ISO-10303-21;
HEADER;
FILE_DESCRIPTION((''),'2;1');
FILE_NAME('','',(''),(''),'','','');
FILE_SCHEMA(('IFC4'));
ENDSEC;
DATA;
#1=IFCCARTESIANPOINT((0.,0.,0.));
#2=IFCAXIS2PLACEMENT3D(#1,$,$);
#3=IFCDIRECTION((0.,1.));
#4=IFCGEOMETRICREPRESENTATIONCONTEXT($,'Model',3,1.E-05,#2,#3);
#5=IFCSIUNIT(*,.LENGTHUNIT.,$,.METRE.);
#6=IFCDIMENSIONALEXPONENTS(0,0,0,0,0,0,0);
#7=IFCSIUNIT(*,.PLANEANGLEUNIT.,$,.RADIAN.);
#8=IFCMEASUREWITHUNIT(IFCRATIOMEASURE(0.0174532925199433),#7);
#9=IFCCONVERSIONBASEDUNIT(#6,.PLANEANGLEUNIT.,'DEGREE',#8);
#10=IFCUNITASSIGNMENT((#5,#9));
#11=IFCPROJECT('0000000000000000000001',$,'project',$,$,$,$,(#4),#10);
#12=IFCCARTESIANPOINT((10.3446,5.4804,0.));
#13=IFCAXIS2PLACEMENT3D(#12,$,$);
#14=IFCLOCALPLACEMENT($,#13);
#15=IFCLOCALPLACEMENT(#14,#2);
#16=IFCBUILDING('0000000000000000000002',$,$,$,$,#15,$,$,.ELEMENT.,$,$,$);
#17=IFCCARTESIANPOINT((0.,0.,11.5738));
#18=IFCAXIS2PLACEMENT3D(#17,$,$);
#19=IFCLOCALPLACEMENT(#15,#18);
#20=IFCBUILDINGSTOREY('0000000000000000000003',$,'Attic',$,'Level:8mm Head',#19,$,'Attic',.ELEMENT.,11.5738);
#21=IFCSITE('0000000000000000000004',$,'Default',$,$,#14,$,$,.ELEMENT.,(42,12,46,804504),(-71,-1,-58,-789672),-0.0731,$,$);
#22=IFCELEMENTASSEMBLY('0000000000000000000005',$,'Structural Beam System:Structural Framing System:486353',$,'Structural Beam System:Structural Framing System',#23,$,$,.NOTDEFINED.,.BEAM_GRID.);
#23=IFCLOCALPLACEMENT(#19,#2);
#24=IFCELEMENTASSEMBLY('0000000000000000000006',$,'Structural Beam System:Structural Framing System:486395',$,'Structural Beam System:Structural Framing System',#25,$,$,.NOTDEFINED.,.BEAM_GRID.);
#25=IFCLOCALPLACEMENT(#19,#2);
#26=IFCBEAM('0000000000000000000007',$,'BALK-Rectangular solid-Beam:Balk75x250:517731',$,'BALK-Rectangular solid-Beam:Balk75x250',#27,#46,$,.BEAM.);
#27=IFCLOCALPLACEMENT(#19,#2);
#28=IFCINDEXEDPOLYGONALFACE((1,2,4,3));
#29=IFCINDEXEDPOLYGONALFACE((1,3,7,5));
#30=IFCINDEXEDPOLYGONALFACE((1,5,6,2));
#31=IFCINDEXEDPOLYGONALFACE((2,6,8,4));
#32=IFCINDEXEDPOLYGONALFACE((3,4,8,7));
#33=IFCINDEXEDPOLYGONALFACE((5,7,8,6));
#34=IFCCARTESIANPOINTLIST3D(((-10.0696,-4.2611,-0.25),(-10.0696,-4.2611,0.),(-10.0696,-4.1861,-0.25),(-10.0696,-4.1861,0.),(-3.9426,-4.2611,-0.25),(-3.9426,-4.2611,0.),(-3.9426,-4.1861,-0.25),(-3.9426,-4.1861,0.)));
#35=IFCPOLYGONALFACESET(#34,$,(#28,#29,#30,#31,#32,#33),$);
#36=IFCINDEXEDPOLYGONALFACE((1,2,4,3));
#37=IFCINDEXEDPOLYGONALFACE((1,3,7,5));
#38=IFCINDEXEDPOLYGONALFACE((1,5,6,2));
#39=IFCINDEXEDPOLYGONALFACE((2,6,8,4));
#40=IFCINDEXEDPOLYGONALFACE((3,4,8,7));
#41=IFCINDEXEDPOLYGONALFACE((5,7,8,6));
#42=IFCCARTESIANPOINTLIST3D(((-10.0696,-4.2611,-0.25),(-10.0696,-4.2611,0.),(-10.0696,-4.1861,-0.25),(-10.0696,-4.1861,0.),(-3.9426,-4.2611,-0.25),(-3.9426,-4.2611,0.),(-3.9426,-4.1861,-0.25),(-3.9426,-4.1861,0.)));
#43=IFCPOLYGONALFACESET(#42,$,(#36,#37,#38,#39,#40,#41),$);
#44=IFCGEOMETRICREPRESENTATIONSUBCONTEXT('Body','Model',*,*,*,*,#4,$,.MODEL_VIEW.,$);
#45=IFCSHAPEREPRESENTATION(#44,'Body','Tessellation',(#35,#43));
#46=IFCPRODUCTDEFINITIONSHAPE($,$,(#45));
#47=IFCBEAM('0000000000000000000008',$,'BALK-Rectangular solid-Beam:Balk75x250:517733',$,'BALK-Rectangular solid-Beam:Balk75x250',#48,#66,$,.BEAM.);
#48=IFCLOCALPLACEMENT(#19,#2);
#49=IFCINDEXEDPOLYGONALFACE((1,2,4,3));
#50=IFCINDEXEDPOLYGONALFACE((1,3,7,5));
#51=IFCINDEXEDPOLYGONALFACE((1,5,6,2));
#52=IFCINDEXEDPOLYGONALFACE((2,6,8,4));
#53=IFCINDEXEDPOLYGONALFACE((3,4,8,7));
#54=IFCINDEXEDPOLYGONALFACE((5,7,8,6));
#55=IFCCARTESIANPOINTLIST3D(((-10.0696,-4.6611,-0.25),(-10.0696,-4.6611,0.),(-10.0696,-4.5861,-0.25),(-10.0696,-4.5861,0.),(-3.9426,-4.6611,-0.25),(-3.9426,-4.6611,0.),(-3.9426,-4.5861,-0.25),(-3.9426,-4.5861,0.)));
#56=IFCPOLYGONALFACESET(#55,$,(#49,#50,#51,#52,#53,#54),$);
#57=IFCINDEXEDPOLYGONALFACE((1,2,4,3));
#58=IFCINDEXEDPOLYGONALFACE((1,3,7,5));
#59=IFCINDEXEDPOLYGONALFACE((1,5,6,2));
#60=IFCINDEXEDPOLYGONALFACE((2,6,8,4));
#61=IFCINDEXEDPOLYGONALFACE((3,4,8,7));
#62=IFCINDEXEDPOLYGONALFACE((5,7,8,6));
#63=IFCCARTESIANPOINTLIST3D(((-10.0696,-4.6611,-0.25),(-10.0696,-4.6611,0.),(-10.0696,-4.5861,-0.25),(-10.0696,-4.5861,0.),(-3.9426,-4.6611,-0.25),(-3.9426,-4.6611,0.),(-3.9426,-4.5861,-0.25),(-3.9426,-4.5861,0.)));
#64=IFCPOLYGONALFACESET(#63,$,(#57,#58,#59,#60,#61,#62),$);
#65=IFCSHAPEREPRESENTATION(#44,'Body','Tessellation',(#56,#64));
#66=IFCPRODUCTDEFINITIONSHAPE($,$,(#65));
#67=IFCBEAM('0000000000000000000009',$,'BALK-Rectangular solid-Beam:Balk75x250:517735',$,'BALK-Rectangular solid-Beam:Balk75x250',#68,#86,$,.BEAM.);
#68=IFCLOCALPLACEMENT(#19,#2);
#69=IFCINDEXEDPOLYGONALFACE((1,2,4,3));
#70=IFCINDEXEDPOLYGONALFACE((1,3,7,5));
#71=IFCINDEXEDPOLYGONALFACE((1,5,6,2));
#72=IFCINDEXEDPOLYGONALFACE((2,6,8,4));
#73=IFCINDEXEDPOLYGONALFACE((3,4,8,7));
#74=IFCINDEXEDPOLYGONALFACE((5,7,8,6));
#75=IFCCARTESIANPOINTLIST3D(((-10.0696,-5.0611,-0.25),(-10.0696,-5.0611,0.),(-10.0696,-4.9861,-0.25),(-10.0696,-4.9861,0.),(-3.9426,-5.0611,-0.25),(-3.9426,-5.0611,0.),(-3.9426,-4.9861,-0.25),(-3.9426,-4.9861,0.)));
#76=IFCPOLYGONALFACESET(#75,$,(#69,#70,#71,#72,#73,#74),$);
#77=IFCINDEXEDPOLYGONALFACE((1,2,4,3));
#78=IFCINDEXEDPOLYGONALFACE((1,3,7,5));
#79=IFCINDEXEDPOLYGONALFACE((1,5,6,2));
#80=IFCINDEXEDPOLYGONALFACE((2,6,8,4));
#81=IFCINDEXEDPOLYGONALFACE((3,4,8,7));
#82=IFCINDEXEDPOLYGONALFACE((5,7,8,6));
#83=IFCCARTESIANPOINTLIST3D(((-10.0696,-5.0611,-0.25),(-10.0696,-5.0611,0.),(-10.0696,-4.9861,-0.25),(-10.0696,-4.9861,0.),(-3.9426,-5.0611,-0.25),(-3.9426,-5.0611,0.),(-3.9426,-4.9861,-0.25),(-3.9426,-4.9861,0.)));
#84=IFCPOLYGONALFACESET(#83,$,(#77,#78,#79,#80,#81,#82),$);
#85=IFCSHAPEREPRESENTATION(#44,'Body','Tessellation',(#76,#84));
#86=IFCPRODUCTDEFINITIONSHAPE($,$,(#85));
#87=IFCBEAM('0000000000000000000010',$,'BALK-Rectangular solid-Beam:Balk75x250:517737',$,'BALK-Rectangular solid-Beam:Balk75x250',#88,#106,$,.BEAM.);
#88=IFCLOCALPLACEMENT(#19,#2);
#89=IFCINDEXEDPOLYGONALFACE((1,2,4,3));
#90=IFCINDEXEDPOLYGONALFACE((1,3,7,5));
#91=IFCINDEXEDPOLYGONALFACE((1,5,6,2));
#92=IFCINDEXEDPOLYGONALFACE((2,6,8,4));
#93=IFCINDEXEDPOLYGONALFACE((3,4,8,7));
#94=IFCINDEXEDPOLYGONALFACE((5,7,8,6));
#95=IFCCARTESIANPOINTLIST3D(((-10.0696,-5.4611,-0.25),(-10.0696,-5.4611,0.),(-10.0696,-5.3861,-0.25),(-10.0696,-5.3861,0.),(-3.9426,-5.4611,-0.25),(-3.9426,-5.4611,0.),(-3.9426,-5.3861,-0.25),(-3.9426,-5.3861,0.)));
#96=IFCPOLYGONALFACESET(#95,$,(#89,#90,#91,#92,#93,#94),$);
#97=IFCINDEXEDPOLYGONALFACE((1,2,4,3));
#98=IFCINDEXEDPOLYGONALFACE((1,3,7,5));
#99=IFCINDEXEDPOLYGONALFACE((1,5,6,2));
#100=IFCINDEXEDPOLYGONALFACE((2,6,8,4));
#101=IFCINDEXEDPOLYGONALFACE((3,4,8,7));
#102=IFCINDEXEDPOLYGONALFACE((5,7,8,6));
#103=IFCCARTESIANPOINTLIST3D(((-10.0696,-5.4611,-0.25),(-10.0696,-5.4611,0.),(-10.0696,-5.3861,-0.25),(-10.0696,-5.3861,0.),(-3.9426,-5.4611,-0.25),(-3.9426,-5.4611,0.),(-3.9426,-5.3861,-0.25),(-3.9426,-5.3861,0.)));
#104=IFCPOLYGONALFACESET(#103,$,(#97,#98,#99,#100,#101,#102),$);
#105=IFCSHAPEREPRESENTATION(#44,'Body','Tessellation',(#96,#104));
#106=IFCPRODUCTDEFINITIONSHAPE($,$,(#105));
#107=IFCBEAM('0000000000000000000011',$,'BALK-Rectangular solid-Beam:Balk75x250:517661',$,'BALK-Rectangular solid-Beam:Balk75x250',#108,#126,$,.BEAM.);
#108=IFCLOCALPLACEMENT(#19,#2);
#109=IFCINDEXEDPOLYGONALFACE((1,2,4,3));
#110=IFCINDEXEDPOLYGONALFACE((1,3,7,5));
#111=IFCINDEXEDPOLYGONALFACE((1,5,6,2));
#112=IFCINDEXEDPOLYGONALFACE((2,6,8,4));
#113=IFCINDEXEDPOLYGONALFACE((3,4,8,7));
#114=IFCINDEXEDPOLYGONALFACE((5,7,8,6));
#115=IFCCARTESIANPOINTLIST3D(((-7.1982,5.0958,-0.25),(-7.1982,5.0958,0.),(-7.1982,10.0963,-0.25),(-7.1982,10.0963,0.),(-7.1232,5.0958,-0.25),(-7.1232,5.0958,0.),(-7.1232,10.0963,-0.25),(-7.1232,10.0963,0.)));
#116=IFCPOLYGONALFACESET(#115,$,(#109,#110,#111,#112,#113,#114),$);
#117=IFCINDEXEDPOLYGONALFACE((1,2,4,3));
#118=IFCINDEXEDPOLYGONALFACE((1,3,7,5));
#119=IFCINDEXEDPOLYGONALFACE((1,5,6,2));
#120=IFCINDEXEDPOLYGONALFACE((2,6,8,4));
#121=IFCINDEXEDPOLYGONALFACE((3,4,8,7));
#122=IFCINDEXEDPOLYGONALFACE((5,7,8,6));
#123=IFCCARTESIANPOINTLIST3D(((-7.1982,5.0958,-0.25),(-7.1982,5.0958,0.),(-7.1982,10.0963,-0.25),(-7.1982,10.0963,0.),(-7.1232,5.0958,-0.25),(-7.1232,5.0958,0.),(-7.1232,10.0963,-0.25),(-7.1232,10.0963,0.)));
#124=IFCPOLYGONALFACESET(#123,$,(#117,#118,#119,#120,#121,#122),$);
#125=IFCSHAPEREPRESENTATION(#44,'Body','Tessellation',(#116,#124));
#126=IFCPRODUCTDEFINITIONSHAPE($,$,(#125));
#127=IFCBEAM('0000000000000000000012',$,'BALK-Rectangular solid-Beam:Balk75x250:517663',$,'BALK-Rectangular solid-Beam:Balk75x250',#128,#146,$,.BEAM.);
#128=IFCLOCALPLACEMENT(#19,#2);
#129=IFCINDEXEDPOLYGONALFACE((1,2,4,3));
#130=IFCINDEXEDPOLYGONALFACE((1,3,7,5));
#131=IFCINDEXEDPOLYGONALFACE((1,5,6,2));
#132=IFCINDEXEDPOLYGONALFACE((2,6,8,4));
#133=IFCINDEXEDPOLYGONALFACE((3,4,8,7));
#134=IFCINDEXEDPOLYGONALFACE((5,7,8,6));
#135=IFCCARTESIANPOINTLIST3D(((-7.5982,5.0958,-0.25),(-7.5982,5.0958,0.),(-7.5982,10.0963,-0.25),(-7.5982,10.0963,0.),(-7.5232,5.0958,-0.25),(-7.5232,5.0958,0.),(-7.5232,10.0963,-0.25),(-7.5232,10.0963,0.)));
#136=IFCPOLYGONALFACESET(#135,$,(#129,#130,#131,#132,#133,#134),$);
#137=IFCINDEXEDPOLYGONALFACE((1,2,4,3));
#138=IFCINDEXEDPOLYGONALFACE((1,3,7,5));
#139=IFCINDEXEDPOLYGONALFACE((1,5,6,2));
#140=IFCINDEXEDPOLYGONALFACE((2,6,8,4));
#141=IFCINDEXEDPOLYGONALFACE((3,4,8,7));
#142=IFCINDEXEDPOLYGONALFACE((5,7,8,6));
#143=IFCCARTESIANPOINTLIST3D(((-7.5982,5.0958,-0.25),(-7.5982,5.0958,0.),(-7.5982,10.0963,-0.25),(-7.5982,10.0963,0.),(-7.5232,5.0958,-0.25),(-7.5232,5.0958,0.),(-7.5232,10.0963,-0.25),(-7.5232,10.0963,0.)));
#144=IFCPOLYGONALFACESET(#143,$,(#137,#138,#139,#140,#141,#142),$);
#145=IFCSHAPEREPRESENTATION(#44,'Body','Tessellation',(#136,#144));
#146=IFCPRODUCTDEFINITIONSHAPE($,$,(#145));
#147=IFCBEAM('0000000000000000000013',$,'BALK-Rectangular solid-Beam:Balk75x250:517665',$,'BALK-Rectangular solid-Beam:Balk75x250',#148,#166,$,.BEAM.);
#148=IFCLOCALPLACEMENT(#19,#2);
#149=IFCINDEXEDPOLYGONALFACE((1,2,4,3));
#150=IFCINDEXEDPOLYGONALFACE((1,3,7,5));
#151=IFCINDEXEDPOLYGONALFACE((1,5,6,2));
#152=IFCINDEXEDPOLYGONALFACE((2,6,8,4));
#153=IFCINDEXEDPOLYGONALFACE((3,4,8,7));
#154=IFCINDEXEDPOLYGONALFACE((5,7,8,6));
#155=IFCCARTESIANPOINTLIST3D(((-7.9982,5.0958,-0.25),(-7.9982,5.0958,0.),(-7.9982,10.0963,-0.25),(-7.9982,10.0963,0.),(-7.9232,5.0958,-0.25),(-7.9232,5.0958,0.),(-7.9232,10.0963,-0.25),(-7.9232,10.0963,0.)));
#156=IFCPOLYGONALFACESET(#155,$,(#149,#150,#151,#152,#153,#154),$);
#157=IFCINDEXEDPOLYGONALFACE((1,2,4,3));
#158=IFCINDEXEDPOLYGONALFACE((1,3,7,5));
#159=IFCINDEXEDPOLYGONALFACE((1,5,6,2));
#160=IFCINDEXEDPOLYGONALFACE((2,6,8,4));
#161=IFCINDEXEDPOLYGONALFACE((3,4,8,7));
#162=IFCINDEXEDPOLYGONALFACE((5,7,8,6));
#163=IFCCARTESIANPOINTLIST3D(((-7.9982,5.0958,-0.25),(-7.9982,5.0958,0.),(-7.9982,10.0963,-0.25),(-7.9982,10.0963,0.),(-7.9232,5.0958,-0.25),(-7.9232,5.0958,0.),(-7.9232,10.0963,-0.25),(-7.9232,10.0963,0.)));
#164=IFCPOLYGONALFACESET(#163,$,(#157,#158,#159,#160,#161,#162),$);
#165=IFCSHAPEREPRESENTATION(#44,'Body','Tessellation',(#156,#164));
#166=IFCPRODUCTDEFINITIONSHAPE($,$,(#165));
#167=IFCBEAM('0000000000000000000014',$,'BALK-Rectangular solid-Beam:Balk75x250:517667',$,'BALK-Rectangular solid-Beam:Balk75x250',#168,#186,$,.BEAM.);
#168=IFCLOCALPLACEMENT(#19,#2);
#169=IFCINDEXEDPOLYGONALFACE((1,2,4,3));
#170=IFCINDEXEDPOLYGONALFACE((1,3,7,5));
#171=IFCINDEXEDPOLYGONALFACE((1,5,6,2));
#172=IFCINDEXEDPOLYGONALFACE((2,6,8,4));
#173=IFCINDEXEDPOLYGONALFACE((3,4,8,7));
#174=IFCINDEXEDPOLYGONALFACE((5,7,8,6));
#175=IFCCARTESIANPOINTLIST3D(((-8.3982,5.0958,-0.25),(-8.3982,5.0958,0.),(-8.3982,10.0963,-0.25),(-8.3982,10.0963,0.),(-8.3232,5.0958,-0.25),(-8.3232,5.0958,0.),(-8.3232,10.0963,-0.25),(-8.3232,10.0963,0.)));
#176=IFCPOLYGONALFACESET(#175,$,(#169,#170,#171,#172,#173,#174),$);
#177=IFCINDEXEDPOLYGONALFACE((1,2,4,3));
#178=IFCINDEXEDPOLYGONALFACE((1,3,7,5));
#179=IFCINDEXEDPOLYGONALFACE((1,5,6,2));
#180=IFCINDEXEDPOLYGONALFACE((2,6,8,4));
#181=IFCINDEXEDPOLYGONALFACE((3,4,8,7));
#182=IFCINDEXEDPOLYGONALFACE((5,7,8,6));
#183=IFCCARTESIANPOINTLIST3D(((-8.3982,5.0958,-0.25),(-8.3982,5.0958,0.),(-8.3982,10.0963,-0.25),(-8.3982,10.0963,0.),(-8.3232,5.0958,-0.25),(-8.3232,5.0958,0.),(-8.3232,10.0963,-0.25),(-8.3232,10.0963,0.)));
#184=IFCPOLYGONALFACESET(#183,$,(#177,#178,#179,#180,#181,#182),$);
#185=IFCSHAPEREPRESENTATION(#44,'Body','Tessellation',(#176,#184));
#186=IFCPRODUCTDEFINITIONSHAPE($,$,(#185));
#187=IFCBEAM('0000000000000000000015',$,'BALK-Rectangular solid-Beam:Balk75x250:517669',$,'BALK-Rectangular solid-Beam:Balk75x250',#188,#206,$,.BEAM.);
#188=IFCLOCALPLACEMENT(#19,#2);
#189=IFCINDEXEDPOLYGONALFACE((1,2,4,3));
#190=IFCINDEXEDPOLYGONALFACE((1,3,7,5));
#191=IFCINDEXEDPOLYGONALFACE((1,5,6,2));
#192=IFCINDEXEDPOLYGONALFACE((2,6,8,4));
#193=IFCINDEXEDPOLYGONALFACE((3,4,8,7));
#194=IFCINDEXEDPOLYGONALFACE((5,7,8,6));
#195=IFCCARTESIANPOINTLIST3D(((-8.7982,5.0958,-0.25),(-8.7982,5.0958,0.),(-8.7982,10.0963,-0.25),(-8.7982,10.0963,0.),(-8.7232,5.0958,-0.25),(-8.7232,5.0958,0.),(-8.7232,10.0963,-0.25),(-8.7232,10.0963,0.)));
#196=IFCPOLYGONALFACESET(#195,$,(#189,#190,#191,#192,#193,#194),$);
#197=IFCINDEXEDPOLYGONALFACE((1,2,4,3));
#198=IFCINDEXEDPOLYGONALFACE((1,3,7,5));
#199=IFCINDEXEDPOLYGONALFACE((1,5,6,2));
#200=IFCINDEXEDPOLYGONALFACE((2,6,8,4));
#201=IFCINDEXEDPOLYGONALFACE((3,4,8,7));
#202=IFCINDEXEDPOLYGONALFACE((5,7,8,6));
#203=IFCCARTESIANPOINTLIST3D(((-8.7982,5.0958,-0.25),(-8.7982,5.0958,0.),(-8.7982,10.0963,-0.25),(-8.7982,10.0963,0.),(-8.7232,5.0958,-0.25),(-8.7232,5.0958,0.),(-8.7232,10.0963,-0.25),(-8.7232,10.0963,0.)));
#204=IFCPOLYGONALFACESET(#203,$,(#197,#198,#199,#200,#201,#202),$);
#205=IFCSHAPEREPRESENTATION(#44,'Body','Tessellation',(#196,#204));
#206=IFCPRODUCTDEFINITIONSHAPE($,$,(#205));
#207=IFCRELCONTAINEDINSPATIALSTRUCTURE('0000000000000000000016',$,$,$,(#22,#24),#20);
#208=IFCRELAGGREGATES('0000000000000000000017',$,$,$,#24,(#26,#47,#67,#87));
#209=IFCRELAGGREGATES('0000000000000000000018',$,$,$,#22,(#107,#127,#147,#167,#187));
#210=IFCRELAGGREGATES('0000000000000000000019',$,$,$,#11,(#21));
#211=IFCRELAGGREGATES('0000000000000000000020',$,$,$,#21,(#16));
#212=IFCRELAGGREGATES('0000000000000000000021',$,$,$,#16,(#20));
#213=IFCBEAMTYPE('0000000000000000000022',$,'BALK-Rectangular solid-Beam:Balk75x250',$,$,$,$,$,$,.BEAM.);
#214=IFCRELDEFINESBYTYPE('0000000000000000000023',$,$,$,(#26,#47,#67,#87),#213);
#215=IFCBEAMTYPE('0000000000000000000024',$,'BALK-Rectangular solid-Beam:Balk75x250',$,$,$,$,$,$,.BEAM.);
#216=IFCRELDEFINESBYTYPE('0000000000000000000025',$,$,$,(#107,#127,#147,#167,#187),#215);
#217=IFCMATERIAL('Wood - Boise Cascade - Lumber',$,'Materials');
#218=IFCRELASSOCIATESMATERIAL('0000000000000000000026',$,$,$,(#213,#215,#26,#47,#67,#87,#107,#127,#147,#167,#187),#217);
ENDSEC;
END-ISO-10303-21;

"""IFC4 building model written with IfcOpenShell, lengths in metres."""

from ifc_helpers import new_model, entity, si_unit, converted_unit, direction, frame, frame_2d, origin, origin_2d_with_axis, place, context, subcontext, project, spatial, rectangle, extrude, source, transform, mapped, material, material_profile, profile_set, profile_usage, type_object, type_shapes, element, aggregate, save


model = new_model("IFC4")

# Units and contexts
model_context = context("Model", 3, precision=1e-05, world=origin(), true_north=direction((0.0, 1.0)))
body_context = subcontext(model_context, "Body", "Model", "MODEL_VIEW")
ifc_project = project(units=[si_unit("LENGTHUNIT", "METRE"), converted_unit("PLANEANGLEUNIT", "DEGREE", entity("IfcRatioMeasure", 0.0174532925199433), si_unit("PLANEANGLEUNIT", "RADIAN"), dimensions=[0, 0, 0, 0, 0, 0, 0])], contexts=[model_context])

# Site, building, storey
site_placement = place(None, frame((10.3446, 5.4804, 0.0)))
site = spatial("IfcSite", under=ifc_project, at=site_placement, Name="Default", CompositionType="ELEMENT", RefLatitude=(42, 12, 46, 804504), RefLongitude=(-71, -1, -58, -789672), RefElevation=-0.0731)
building_placement = place(site_placement, origin())
building = spatial("IfcBuilding", under=site, at=building_placement, CompositionType="ELEMENT")
storey_placement = place(building_placement, frame((0.0, 0.0, 11.5738)))
storey = spatial("IfcBuildingStorey", under=building, at=storey_placement, Name="Attic", ObjectType="Level:8mm Head", LongName="Attic", CompositionType="ELEMENT", Elevation=11.5738)

# Element assemblies, beams
assembly_1_placement = place(storey_placement, origin())
assembly_1 = element("IfcElementAssembly", 1, at=assembly_1_placement, inside=storey, Name="Structural Beam System:Structural Framing System:486353", ObjectType="Structural Beam System:Structural Framing System", AssemblyPlace="NOTDEFINED", PredefinedType="BEAM_GRID")
ifc_material = material(Name="Wood - Boise Cascade - Lumber", Category="Materials")
ifc_material_profile = material_profile(ifc_material, rectangle(XDim=0.25, YDim=0.075, at=frame_2d((0.0, 0.0), x_axis=(1.0, 0.0))), Name="Balk75x250")
ifc_profile_set = profile_set([ifc_material_profile], Name="Balk75x250")
assembly_2_placement = place(storey_placement, origin())
assembly_2 = element("IfcElementAssembly", 2, at=assembly_2_placement, inside=storey, Name="Structural Beam System:Structural Framing System:486395", ObjectType="Structural Beam System:Structural Framing System", AssemblyPlace="NOTDEFINED", PredefinedType="BEAM_GRID")
beam_type_1 = type_object("IfcBeamType", Name="BALK-Rectangular solid-Beam:Balk75x250", PredefinedType="BEAM", material=ifc_profile_set)
shared_shape_1 = source(origin(), body_context, "Body", "SweptSolid", [
    extrude(rectangle(XDim=0.25, YDim=0.075, at=origin_2d_with_axis()), frame((-2.9698, 0.0, 0.0), z_axis=(1.0, 0.0, 0.0), x_axis=(0.0, 0.0, -1.0)), (0.0, 0.0, 1.0), 6.127),
    extrude(rectangle(XDim=0.25, YDim=0.075, at=origin_2d_with_axis()), frame((-2.9698, 0.0, 0.0), z_axis=(1.0, 0.0, 0.0), x_axis=(0.0, 0.0, -1.0)), (0.0, 0.0, 1.0), 6.127),
])
type_shapes(beam_type_1, [shared_shape_1])
ifc_profile_usage_1 = profile_usage(ifc_profile_set, cardinal=8)
beam_1_placement = place(assembly_2_placement, frame((-7.0999, -4.2236, -0.125)))
beam_1 = element("IfcBeam", 3, at=beam_1_placement, type_object=beam_type_1, material=ifc_profile_usage_1, Name="BALK-Rectangular solid-Beam:Balk75x250:517731", ObjectType="BALK-Rectangular solid-Beam:Balk75x250", PredefinedType="BEAM", context=body_context, shape_type="MappedRepresentation", body=[
    mapped(shared_shape_1, transform((0.0, 0.0, 0.0), scale=1.0)),
])
ifc_profile_usage_2 = profile_usage(ifc_profile_set, cardinal=8)
beam_2_placement = place(assembly_2_placement, frame((-7.0999, -4.6236, -0.125)))
beam_2 = element("IfcBeam", 4, at=beam_2_placement, type_object=beam_type_1, material=ifc_profile_usage_2, Name="BALK-Rectangular solid-Beam:Balk75x250:517733", ObjectType="BALK-Rectangular solid-Beam:Balk75x250", PredefinedType="BEAM", context=body_context, shape_type="MappedRepresentation", body=[
    mapped(shared_shape_1, transform((0.0, 0.0, 0.0), scale=1.0)),
])
ifc_profile_usage_3 = profile_usage(ifc_profile_set, cardinal=8)
beam_3_placement = place(assembly_2_placement, frame((-7.0999, -5.0236, -0.125)))
beam_3 = element("IfcBeam", 5, at=beam_3_placement, type_object=beam_type_1, material=ifc_profile_usage_3, Name="BALK-Rectangular solid-Beam:Balk75x250:517735", ObjectType="BALK-Rectangular solid-Beam:Balk75x250", PredefinedType="BEAM", context=body_context, shape_type="MappedRepresentation", body=[
    mapped(shared_shape_1, transform((0.0, 0.0, 0.0), scale=1.0)),
])
ifc_profile_usage_4 = profile_usage(ifc_profile_set, cardinal=8)
beam_4_placement = place(assembly_2_placement, frame((-7.0999, -5.4236, -0.125)))
beam_4 = element("IfcBeam", 6, at=beam_4_placement, type_object=beam_type_1, material=ifc_profile_usage_4, Name="BALK-Rectangular solid-Beam:Balk75x250:517737", ObjectType="BALK-Rectangular solid-Beam:Balk75x250", PredefinedType="BEAM", context=body_context, shape_type="MappedRepresentation", body=[
    mapped(shared_shape_1, transform((0.0, 0.0, 0.0), scale=1.0)),
])
aggregate(assembly_2, [beam_1, beam_2, beam_3, beam_4])

# Beams
ifc_profile_usage_5 = profile_usage(ifc_profile_set, cardinal=8)
beam_type_2 = type_object("IfcBeamType", Name="BALK-Rectangular solid-Beam:Balk75x250", PredefinedType="BEAM", material=ifc_profile_set)
shared_shape_2 = source(origin(), body_context, "Body", "SweptSolid", [
    extrude(rectangle(XDim=0.25, YDim=0.075, at=origin_2d_with_axis()), frame((-2.394, 0.0, 0.0), z_axis=(1.0, 0.0, 0.0), x_axis=(0.0, 0.0, -1.0)), (0.0, 0.0, 1.0), 5.0005),
    extrude(rectangle(XDim=0.25, YDim=0.075, at=origin_2d_with_axis()), frame((-2.394, 0.0, 0.0), z_axis=(1.0, 0.0, 0.0), x_axis=(0.0, 0.0, -1.0)), (0.0, 0.0, 1.0), 5.0005),
])
type_shapes(beam_type_2, [shared_shape_2])
beam_5_placement = place(assembly_1_placement, frame((-7.1607, 7.7023, -0.125), z_axis=(0.0, 0.0, 1.0), x_axis=(0.0, -1.0, 0.0)))
beam_5 = element("IfcBeam", 7, at=beam_5_placement, type_object=beam_type_2, material=ifc_profile_usage_5, Name="BALK-Rectangular solid-Beam:Balk75x250:517661", ObjectType="BALK-Rectangular solid-Beam:Balk75x250", PredefinedType="BEAM", context=body_context, shape_type="MappedRepresentation", body=[
    mapped(shared_shape_2, transform((0.0, 0.0, 0.0), scale=1.0)),
])
ifc_profile_usage_6 = profile_usage(ifc_profile_set, cardinal=8)
beam_6_placement = place(assembly_1_placement, frame((-7.5607, 7.7023, -0.125), z_axis=(0.0, 0.0, 1.0), x_axis=(0.0, -1.0, 0.0)))
beam_6 = element("IfcBeam", 8, at=beam_6_placement, type_object=beam_type_2, material=ifc_profile_usage_6, Name="BALK-Rectangular solid-Beam:Balk75x250:517663", ObjectType="BALK-Rectangular solid-Beam:Balk75x250", PredefinedType="BEAM", context=body_context, shape_type="MappedRepresentation", body=[
    mapped(shared_shape_2, transform((0.0, 0.0, 0.0), scale=1.0)),
])
ifc_profile_usage_7 = profile_usage(ifc_profile_set, cardinal=8)
beam_7_placement = place(assembly_1_placement, frame((-7.9607, 7.7023, -0.125), z_axis=(0.0, 0.0, 1.0), x_axis=(0.0, -1.0, 0.0)))
beam_7 = element("IfcBeam", 9, at=beam_7_placement, type_object=beam_type_2, material=ifc_profile_usage_7, Name="BALK-Rectangular solid-Beam:Balk75x250:517665", ObjectType="BALK-Rectangular solid-Beam:Balk75x250", PredefinedType="BEAM", context=body_context, shape_type="MappedRepresentation", body=[
    mapped(shared_shape_2, transform((0.0, 0.0, 0.0), scale=1.0)),
])
ifc_profile_usage_8 = profile_usage(ifc_profile_set, cardinal=8)
beam_8_placement = place(assembly_1_placement, frame((-8.3607, 7.7023, -0.125), z_axis=(0.0, 0.0, 1.0), x_axis=(0.0, -1.0, 0.0)))
beam_8 = element("IfcBeam", 10, at=beam_8_placement, type_object=beam_type_2, material=ifc_profile_usage_8, Name="BALK-Rectangular solid-Beam:Balk75x250:517667", ObjectType="BALK-Rectangular solid-Beam:Balk75x250", PredefinedType="BEAM", context=body_context, shape_type="MappedRepresentation", body=[
    mapped(shared_shape_2, transform((0.0, 0.0, 0.0), scale=1.0)),
])
ifc_profile_usage_9 = profile_usage(ifc_profile_set, cardinal=8)
beam_9_placement = place(assembly_1_placement, frame((-8.7607, 7.7023, -0.125), z_axis=(0.0, 0.0, 1.0), x_axis=(0.0, -1.0, 0.0)))
beam_9 = element("IfcBeam", 11, at=beam_9_placement, type_object=beam_type_2, material=ifc_profile_usage_9, Name="BALK-Rectangular solid-Beam:Balk75x250:517669", ObjectType="BALK-Rectangular solid-Beam:Balk75x250", PredefinedType="BEAM", context=body_context, shape_type="MappedRepresentation", body=[
    mapped(shared_shape_2, transform((0.0, 0.0, 0.0), scale=1.0)),
])
aggregate(assembly_1, [beam_5, beam_6, beam_7, beam_8, beam_9])

save(model, "model.ifc")
